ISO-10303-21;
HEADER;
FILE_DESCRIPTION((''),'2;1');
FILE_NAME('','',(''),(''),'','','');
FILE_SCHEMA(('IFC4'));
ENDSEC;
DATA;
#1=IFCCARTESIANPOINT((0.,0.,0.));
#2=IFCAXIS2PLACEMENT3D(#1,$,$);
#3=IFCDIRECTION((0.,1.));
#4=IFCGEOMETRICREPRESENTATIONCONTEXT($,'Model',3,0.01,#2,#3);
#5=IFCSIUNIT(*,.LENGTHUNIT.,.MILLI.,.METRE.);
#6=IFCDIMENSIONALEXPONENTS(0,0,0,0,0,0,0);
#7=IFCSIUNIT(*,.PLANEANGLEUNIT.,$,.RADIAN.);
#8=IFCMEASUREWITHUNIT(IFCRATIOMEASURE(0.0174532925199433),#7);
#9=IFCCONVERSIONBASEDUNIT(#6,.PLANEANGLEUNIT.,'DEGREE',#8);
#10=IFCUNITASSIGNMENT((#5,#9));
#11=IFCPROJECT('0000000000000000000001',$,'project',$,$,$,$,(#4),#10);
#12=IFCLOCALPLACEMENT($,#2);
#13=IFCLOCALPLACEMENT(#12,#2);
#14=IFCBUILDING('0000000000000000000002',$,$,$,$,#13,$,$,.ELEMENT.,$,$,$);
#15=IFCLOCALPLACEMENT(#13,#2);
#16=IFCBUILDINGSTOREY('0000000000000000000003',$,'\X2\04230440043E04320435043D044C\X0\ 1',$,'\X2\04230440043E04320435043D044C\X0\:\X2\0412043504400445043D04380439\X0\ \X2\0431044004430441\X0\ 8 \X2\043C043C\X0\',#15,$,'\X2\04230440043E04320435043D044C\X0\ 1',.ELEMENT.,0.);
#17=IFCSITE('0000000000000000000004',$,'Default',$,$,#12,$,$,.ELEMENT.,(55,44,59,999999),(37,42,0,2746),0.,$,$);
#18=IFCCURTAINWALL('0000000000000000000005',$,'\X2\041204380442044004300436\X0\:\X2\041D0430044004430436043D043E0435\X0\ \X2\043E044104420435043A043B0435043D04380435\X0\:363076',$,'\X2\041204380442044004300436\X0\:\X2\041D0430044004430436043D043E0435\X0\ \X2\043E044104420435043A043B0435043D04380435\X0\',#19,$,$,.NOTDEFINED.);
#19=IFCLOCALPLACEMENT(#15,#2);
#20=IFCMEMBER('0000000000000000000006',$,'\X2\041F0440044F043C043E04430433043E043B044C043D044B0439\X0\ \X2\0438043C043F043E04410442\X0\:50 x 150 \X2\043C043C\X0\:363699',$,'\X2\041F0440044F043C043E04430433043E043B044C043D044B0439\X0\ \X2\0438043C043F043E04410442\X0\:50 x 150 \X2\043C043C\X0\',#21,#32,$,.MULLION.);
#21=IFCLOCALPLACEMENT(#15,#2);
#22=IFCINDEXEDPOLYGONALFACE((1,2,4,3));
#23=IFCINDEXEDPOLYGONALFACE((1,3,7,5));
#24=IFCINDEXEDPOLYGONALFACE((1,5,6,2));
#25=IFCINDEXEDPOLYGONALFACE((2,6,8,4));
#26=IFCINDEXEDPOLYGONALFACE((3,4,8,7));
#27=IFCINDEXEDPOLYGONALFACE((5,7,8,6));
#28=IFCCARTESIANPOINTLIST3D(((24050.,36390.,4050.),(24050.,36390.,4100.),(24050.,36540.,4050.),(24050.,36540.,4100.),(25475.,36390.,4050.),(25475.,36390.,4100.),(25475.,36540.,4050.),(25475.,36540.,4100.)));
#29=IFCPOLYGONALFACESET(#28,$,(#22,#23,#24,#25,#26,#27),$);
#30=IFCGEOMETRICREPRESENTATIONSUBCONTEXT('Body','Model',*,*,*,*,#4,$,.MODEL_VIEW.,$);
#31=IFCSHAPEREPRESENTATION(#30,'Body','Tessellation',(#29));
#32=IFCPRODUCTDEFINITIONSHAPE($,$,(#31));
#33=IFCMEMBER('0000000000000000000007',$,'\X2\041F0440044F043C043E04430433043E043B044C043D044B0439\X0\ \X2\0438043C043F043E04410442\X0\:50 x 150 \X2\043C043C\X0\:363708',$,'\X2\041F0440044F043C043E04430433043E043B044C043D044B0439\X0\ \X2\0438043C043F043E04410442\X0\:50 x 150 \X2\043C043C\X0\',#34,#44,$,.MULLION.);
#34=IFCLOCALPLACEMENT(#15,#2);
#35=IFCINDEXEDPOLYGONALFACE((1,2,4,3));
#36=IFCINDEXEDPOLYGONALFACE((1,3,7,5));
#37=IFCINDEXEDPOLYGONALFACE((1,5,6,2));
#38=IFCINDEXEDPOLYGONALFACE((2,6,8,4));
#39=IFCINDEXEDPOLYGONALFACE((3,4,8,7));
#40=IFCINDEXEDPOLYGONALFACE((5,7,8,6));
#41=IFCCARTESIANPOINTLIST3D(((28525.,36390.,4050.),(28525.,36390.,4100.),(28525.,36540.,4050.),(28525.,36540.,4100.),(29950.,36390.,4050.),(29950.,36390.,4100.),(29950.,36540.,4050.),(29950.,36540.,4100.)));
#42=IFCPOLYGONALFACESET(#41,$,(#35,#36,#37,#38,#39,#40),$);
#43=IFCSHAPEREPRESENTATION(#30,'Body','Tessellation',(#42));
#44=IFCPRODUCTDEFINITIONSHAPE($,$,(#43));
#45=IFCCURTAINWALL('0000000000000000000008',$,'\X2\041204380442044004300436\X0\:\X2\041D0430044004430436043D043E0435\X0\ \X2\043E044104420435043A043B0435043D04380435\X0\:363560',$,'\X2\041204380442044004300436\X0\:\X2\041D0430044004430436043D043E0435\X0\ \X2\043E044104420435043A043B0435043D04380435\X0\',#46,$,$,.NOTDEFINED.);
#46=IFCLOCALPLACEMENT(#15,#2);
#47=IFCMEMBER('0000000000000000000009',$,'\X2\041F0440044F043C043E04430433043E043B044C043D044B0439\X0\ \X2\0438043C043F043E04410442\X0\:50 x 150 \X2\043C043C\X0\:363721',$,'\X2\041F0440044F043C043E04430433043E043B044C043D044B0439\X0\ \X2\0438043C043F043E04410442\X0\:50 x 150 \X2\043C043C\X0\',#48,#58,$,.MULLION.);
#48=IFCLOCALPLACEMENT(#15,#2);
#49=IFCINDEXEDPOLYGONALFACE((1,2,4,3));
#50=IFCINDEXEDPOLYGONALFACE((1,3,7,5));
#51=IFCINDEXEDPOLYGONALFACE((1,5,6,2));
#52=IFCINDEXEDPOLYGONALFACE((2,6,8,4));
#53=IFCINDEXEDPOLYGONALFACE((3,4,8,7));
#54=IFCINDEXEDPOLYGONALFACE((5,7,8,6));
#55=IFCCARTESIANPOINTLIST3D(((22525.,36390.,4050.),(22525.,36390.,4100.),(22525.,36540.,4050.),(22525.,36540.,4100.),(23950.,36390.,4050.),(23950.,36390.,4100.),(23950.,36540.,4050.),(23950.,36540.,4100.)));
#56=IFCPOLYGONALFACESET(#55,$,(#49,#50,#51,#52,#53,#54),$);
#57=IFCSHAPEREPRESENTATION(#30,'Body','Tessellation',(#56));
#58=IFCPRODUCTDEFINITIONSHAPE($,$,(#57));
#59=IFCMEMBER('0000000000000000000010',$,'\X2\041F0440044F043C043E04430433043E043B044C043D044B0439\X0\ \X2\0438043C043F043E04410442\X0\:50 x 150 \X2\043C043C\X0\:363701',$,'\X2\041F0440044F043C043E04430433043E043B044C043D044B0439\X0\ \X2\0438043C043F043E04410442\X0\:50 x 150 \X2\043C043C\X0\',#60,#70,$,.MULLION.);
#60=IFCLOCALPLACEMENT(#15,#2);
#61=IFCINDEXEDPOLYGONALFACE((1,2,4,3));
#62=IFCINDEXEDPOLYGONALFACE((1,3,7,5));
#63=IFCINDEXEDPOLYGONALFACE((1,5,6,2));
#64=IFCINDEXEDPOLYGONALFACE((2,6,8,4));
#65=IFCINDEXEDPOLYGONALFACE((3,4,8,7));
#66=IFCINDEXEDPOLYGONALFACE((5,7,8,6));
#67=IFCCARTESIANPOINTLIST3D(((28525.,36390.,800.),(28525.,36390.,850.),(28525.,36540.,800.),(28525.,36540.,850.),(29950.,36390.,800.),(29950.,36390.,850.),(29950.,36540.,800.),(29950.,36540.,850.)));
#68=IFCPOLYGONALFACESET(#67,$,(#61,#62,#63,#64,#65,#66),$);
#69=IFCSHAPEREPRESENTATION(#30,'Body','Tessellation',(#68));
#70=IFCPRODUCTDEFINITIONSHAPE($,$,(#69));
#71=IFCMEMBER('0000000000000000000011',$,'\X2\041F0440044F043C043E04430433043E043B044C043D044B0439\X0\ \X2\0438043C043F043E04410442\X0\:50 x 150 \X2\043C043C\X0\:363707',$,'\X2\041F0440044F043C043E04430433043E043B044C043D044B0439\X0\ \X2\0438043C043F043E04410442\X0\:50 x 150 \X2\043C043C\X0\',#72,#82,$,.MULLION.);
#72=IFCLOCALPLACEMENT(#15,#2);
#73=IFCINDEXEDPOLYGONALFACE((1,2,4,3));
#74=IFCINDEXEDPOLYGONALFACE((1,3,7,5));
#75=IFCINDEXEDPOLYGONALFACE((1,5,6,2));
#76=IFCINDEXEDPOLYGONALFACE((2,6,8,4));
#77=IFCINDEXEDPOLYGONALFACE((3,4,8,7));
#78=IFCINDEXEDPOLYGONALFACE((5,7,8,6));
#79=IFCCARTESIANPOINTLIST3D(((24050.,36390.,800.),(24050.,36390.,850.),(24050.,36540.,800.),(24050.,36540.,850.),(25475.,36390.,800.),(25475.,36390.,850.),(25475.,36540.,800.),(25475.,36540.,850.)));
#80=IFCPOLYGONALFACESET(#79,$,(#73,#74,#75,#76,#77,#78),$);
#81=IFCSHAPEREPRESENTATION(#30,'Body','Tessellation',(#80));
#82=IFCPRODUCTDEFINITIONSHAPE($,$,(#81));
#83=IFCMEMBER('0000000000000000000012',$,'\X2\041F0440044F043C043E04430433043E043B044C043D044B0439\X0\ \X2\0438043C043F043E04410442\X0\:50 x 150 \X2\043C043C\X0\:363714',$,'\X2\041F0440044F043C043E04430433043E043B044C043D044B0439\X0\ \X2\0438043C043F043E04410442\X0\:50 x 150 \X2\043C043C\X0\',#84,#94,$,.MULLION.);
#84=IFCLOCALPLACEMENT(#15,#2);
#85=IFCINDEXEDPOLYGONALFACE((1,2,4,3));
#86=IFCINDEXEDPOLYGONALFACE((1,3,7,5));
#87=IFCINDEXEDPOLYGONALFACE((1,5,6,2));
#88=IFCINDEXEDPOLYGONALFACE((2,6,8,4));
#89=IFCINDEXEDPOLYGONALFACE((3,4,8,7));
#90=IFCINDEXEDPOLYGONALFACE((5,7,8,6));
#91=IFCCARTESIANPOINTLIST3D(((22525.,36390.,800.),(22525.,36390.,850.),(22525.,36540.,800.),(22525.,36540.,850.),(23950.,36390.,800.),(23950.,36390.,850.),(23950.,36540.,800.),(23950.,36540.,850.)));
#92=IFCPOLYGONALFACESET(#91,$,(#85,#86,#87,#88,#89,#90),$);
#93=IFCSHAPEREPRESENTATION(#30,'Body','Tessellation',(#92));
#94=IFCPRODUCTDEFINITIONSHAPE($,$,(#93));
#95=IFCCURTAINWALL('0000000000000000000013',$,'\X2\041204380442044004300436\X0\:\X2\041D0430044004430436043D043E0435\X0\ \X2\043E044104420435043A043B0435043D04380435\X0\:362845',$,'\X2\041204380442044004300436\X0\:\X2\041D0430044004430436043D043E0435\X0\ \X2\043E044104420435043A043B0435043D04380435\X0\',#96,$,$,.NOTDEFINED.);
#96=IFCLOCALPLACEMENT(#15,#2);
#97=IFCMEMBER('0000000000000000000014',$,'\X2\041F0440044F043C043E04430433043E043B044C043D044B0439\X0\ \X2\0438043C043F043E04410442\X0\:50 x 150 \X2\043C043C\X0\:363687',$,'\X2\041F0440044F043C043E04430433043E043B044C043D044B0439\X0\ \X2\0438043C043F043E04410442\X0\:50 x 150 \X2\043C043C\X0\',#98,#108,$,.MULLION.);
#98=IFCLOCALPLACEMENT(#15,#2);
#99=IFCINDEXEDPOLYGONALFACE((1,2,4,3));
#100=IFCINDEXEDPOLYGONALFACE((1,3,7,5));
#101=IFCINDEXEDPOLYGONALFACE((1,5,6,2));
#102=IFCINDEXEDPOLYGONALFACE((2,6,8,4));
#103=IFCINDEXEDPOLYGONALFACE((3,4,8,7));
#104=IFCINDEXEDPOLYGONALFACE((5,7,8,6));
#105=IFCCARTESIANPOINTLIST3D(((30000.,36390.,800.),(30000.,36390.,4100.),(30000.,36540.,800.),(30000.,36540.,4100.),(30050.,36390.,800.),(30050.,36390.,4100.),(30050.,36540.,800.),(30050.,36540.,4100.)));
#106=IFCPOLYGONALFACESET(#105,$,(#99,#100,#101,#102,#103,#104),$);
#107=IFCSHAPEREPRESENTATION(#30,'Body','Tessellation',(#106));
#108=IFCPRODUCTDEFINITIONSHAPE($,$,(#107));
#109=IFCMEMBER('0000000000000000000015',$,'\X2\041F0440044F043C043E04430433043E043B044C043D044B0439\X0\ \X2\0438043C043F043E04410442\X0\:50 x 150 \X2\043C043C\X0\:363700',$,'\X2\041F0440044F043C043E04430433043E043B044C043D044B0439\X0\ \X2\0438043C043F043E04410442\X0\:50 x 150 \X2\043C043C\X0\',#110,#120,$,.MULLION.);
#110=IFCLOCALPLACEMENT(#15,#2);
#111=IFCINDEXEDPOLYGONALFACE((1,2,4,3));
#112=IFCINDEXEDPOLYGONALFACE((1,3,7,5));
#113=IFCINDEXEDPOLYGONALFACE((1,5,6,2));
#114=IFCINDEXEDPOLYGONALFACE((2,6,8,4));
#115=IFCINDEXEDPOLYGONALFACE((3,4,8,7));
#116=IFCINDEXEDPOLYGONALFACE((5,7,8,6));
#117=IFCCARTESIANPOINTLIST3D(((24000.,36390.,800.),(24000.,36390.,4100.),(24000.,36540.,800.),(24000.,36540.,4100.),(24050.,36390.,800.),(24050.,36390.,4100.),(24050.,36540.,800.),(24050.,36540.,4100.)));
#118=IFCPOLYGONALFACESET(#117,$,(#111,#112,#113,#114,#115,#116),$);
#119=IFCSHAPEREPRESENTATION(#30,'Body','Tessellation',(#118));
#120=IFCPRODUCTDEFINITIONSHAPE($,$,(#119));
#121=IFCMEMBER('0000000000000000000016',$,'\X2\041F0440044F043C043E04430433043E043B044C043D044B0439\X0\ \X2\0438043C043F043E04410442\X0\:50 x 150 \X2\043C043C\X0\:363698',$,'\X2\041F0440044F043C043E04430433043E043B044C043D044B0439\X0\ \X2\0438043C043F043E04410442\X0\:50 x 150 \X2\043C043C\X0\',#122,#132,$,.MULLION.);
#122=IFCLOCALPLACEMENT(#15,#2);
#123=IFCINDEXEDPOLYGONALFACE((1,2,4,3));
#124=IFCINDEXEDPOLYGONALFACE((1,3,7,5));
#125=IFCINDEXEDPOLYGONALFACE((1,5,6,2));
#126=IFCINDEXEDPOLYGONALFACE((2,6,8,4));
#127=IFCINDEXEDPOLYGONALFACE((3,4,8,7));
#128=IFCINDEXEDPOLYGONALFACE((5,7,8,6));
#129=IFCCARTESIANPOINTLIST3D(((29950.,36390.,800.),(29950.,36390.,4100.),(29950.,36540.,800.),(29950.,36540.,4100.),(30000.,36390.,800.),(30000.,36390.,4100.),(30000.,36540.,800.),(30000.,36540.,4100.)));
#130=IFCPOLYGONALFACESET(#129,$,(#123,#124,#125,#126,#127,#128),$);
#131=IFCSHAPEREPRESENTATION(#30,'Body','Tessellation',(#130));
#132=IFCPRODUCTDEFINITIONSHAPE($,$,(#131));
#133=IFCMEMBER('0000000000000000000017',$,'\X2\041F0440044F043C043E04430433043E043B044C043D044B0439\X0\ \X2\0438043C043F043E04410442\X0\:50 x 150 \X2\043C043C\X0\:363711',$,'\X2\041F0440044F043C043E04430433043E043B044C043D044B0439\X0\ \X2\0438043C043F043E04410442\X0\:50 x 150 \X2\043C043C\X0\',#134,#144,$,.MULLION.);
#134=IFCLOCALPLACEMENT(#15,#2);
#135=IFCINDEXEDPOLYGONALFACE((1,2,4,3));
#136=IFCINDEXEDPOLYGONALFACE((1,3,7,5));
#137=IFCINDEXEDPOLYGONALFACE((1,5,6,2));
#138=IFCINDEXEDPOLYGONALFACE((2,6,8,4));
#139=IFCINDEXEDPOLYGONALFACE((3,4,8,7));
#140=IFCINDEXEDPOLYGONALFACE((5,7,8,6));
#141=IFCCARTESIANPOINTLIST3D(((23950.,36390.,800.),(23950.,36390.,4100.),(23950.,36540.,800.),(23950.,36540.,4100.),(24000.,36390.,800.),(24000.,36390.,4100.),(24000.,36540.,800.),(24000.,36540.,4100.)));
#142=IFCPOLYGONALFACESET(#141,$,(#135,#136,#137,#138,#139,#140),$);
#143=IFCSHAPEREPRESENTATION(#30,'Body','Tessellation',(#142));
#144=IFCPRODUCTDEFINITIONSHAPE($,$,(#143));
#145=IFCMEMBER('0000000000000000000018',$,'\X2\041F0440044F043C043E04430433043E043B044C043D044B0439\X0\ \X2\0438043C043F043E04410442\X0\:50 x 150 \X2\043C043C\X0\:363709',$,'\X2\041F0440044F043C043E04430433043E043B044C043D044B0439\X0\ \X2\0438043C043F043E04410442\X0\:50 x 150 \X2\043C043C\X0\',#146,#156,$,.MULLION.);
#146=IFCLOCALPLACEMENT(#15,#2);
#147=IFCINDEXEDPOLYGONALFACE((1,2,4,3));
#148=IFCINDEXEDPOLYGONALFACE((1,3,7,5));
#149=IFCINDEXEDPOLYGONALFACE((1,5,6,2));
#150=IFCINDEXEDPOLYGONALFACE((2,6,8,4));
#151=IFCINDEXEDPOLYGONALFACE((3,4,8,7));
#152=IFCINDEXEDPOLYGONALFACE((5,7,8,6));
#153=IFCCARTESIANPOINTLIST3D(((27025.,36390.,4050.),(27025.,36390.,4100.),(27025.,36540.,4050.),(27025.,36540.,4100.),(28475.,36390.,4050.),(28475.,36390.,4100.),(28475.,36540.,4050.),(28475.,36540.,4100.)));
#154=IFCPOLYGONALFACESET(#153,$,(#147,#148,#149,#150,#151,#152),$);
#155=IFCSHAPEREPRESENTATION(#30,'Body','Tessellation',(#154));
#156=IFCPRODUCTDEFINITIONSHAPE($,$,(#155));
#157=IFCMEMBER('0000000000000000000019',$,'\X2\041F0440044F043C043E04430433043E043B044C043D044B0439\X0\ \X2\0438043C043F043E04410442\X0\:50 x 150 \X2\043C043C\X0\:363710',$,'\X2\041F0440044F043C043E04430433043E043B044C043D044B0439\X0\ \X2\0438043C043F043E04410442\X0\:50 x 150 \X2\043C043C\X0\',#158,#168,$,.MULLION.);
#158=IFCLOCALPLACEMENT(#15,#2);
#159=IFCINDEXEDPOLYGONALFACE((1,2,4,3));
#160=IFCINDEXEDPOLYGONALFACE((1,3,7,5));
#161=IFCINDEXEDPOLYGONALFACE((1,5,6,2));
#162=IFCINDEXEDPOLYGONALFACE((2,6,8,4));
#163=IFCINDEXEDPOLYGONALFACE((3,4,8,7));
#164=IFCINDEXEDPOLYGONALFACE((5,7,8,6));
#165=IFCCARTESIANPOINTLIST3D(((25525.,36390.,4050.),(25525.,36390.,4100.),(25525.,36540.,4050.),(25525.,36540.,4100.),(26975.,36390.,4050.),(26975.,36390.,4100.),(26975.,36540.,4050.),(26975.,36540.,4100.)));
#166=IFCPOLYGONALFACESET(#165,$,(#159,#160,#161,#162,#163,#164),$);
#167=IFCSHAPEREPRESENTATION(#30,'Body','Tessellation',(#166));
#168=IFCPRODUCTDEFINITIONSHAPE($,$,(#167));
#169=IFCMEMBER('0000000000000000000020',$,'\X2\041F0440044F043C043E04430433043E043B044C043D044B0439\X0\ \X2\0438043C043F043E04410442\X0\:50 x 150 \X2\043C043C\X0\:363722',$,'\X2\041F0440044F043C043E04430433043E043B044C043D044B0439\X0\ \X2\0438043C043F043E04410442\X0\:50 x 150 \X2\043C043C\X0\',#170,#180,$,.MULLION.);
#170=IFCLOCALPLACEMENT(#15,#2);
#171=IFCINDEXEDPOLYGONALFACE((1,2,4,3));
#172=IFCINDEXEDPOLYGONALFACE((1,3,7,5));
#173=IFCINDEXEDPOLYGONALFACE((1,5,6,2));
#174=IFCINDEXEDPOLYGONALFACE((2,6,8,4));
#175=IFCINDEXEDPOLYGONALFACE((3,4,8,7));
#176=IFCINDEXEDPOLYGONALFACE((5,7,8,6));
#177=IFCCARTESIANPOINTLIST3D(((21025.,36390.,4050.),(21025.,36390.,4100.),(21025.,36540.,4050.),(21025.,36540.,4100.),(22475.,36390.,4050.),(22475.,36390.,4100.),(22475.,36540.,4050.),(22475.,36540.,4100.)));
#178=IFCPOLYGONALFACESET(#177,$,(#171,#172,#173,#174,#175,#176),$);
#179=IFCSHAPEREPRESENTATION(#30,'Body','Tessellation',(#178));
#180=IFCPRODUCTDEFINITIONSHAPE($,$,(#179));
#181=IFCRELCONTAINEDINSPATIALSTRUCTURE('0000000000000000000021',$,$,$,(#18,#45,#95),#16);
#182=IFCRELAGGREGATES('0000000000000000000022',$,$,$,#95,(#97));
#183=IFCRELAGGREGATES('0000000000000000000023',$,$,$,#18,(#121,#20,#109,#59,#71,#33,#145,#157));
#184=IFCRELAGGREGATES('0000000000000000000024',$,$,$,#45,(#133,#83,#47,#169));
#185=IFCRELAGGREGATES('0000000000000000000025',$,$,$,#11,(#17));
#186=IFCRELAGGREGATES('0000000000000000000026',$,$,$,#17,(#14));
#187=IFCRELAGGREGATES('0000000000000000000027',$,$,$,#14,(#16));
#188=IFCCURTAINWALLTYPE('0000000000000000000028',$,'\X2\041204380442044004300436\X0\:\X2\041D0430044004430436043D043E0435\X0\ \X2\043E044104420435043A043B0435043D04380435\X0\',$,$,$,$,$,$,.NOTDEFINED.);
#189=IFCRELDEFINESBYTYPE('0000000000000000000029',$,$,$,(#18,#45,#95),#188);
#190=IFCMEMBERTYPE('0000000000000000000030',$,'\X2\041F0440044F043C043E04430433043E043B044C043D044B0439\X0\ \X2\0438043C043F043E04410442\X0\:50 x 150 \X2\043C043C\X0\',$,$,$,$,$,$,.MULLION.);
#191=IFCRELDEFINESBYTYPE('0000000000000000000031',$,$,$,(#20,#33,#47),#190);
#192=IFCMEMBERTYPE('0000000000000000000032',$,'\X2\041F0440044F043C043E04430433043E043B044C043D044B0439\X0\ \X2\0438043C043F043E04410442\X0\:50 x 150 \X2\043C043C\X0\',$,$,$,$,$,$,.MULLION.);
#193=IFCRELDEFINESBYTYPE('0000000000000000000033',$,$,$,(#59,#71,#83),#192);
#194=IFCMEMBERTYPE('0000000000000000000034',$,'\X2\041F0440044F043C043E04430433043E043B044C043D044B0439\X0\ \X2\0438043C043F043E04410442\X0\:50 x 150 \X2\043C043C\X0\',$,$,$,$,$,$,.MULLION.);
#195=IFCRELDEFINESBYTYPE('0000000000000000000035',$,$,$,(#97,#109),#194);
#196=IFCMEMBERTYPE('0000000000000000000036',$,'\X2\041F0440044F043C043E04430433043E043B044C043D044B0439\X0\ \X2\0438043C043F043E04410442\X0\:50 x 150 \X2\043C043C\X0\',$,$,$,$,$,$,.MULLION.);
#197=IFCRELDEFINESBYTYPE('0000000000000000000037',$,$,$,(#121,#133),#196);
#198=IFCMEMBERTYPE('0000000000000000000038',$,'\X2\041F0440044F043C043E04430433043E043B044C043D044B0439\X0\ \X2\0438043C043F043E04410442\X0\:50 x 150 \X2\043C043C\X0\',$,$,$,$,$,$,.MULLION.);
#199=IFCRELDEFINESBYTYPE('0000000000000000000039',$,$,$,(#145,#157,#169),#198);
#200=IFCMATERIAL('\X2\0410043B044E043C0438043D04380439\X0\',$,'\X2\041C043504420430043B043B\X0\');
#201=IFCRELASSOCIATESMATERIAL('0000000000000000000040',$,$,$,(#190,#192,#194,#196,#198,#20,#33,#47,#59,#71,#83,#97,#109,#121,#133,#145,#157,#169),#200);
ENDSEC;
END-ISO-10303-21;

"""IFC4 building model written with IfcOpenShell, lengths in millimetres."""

from ifc_helpers import new_model, entity, si_unit, converted_unit, direction, frame, origin, origin_2d_with_axis, place, context, subcontext, project, spatial, rectangle, extrude, source, transform, mapped, material, material_profile, profile_set, profile_usage, type_object, type_shapes, element, aggregate, save


model = new_model("IFC4")

# Units and contexts
model_context = context("Model", 3, precision=0.01, world=origin(), true_north=direction((0.0, 1.0)))
body_context = subcontext(model_context, "Body", "Model", "MODEL_VIEW")
ifc_project = project(units=[si_unit("LENGTHUNIT", "METRE", prefix="MILLI"), converted_unit("PLANEANGLEUNIT", "DEGREE", entity("IfcRatioMeasure", 0.0174532925199433), si_unit("PLANEANGLEUNIT", "RADIAN"), dimensions=[0, 0, 0, 0, 0, 0, 0])], contexts=[model_context])

# Site, building, storey
site_placement = place(None, origin())
site = spatial("IfcSite", under=ifc_project, at=site_placement, Name="Default", CompositionType="ELEMENT", RefLatitude=(55, 44, 59, 999999), RefLongitude=(37, 42, 0, 2746), RefElevation=0.0)
building_placement = place(site_placement, origin())
building = spatial("IfcBuilding", under=site, at=building_placement, CompositionType="ELEMENT")
storey_placement = place(building_placement, origin())
storey = spatial("IfcBuildingStorey", under=building, at=storey_placement, Name="Уровень 1", ObjectType="Уровень:Верхний брус 8 мм", LongName="Уровень 1", CompositionType="ELEMENT", Elevation=0.0)

# Curtain wall, members
curtain_wall_type = type_object("IfcCurtainWallType", Name="Витраж:Наружное остекление", PredefinedType="NOTDEFINED")
curtain_wall_1_placement = place(storey_placement, origin())
curtain_wall_1 = element("IfcCurtainWall", 1, at=curtain_wall_1_placement, inside=storey, type_object=curtain_wall_type, Name="Витраж:Наружное остекление:363076", ObjectType="Витраж:Наружное остекление", PredefinedType="NOTDEFINED")
ifc_material_1 = material(Name="Алюминий", Category="Металл")
ifc_material_profile = material_profile(ifc_material_1, rectangle(XDim=150.0, YDim=50.0, at=origin_2d_with_axis()), Name="50 x 150 мм")
ifc_profile_set = profile_set([ifc_material_profile], Name="50 x 150 мм")
ifc_profile_usage_1 = profile_usage(ifc_profile_set)
member_type_1 = type_object("IfcMemberType", Name="Прямоугольный импост:50 x 150 мм", PredefinedType="MULLION", material=ifc_profile_set)
shared_shape_1 = source(origin(), body_context, "Body", "SweptSolid", [
    extrude(rectangle(XDim=150.0, YDim=50.0, at=origin_2d_with_axis()), frame((-25.0, 0.0, -1425.0), z_axis=(0.0, 0.0, 1.0), x_axis=(0.0, -1.0, 0.0)), (0.0, 0.0, 1.0), 1425.0),
])
type_shapes(member_type_1, [shared_shape_1])
member_1_placement = place(storey_placement, frame((24050.0, 36465.0, 4100.0), z_axis=(-1.0, 0.0, 0.0), x_axis=(0.0, 0.0, 1.0)))
member_1 = element("IfcMember", 2, at=member_1_placement, type_object=member_type_1, material=ifc_profile_usage_1, Name="Прямоугольный импост:50 x 150 мм:363699", ObjectType="Прямоугольный импост:50 x 150 мм", PredefinedType="MULLION", context=body_context, shape_type="MappedRepresentation", body=[
    mapped(shared_shape_1, transform((0.0, 0.0, 0.0), scale=1.0)),
])
ifc_profile_usage_2 = profile_usage(ifc_profile_set)
member_2_placement = place(storey_placement, frame((28525.0, 36465.0, 4100.0), z_axis=(-1.0, 0.0, 0.0), x_axis=(0.0, 0.0, 1.0)))
member_2 = element("IfcMember", 3, at=member_2_placement, type_object=member_type_1, material=ifc_profile_usage_2, Name="Прямоугольный импост:50 x 150 мм:363708", ObjectType="Прямоугольный импост:50 x 150 мм", PredefinedType="MULLION", context=body_context, shape_type="MappedRepresentation", body=[
    mapped(shared_shape_1, transform((0.0, 0.0, 0.0), scale=1.0)),
])

# Curtain wall, member
curtain_wall_2_placement = place(storey_placement, origin())
curtain_wall_2 = element("IfcCurtainWall", 4, at=curtain_wall_2_placement, inside=storey, type_object=curtain_wall_type, Name="Витраж:Наружное остекление:363560", ObjectType="Витраж:Наружное остекление", PredefinedType="NOTDEFINED")
ifc_profile_usage_3 = profile_usage(ifc_profile_set)
member_3_placement = place(storey_placement, frame((22525.0, 36465.0, 4100.0), z_axis=(-1.0, 0.0, 0.0), x_axis=(0.0, 0.0, 1.0)))
member_3 = element("IfcMember", 5, at=member_3_placement, type_object=member_type_1, material=ifc_profile_usage_3, Name="Прямоугольный импост:50 x 150 мм:363721", ObjectType="Прямоугольный импост:50 x 150 мм", PredefinedType="MULLION", context=body_context, shape_type="MappedRepresentation", body=[
    mapped(shared_shape_1, transform((0.0, 0.0, 0.0), scale=1.0)),
])

# Members
ifc_profile_usage_4 = profile_usage(ifc_profile_set)
member_type_2 = type_object("IfcMemberType", Name="Прямоугольный импост:50 x 150 мм", PredefinedType="MULLION", material=ifc_profile_set)
shared_shape_2 = source(origin(), body_context, "Body", "SweptSolid", [
    extrude(rectangle(XDim=150.0, YDim=50.0, at=origin_2d_with_axis()), frame((-25.0, 0.0, -1425.0), z_axis=(0.0, 0.0, 1.0), x_axis=(0.0, -1.0, 0.0)), (0.0, 0.0, 1.0), 1425.0),
])
type_shapes(member_type_2, [shared_shape_2])
member_4_placement = place(storey_placement, frame((29950.0, 36465.0, 800.0), z_axis=(1.0, 0.0, 0.0), x_axis=(0.0, 0.0, -1.0)))
member_4 = element("IfcMember", 6, at=member_4_placement, type_object=member_type_2, material=ifc_profile_usage_4, Name="Прямоугольный импост:50 x 150 мм:363701", ObjectType="Прямоугольный импост:50 x 150 мм", PredefinedType="MULLION", context=body_context, shape_type="MappedRepresentation", body=[
    mapped(shared_shape_2, transform((0.0, 0.0, 0.0), scale=1.0)),
])
ifc_profile_usage_5 = profile_usage(ifc_profile_set)
member_5_placement = place(storey_placement, frame((25475.0, 36465.0, 800.0), z_axis=(1.0, 0.0, 0.0), x_axis=(0.0, 0.0, -1.0)))
member_5 = element("IfcMember", 7, at=member_5_placement, type_object=member_type_2, material=ifc_profile_usage_5, Name="Прямоугольный импост:50 x 150 мм:363707", ObjectType="Прямоугольный импост:50 x 150 мм", PredefinedType="MULLION", context=body_context, shape_type="MappedRepresentation", body=[
    mapped(shared_shape_2, transform((0.0, 0.0, 0.0), scale=1.0)),
])
ifc_profile_usage_6 = profile_usage(ifc_profile_set)
member_6_placement = place(storey_placement, frame((23950.0, 36465.0, 800.0), z_axis=(1.0, 0.0, 0.0), x_axis=(0.0, 0.0, -1.0)))
member_6 = element("IfcMember", 8, at=member_6_placement, type_object=member_type_2, material=ifc_profile_usage_6, Name="Прямоугольный импост:50 x 150 мм:363714", ObjectType="Прямоугольный импост:50 x 150 мм", PredefinedType="MULLION", context=body_context, shape_type="MappedRepresentation", body=[
    mapped(shared_shape_2, transform((0.0, 0.0, 0.0), scale=1.0)),
])

# Curtain wall, member
curtain_wall_3_placement = place(storey_placement, origin())
curtain_wall_3 = element("IfcCurtainWall", 9, at=curtain_wall_3_placement, inside=storey, type_object=curtain_wall_type, Name="Витраж:Наружное остекление:362845", ObjectType="Витраж:Наружное остекление", PredefinedType="NOTDEFINED")
ifc_profile_usage_7 = profile_usage(ifc_profile_set)
member_type_3 = type_object("IfcMemberType", Name="Прямоугольный импост:50 x 150 мм", PredefinedType="MULLION", material=ifc_profile_set)
shared_shape_3 = source(origin(), body_context, "Body", "SweptSolid", [
    extrude(rectangle(XDim=150.0, YDim=50.0, at=origin_2d_with_axis()), frame((-25.0, 0.0, -3300.0), z_axis=(0.0, 0.0, 1.0), x_axis=(0.0, -1.0, 0.0)), (0.0, 0.0, 1.0), 3300.0),
])
type_shapes(member_type_3, [shared_shape_3])
member_7_placement = place(storey_placement, frame((30000.0, 36465.0, 800.0), z_axis=(0.0, 0.0, -1.0), x_axis=(-1.0, 0.0, 0.0)))
member_7 = element("IfcMember", 10, at=member_7_placement, type_object=member_type_3, material=ifc_profile_usage_7, Name="Прямоугольный импост:50 x 150 мм:363687", ObjectType="Прямоугольный импост:50 x 150 мм", PredefinedType="MULLION", context=body_context, shape_type="MappedRepresentation", body=[
    mapped(shared_shape_3, transform((0.0, 0.0, 0.0), scale=1.0)),
])
aggregate(curtain_wall_3, [member_7])

# Members
ifc_profile_usage_8 = profile_usage(ifc_profile_set)
member_8_placement = place(storey_placement, frame((24000.0, 36465.0, 800.0), z_axis=(0.0, 0.0, -1.0), x_axis=(-1.0, 0.0, 0.0)))
member_8 = element("IfcMember", 11, at=member_8_placement, type_object=member_type_3, material=ifc_profile_usage_8, Name="Прямоугольный импост:50 x 150 мм:363700", ObjectType="Прямоугольный импост:50 x 150 мм", PredefinedType="MULLION", context=body_context, shape_type="MappedRepresentation", body=[
    mapped(shared_shape_3, transform((0.0, 0.0, 0.0), scale=1.0)),
])
ifc_profile_usage_9 = profile_usage(ifc_profile_set)
member_type_4 = type_object("IfcMemberType", Name="Прямоугольный импост:50 x 150 мм", PredefinedType="MULLION", material=ifc_profile_set)
shared_shape_4 = source(origin(), body_context, "Body", "SweptSolid", [
    extrude(rectangle(XDim=150.0, YDim=50.0, at=origin_2d_with_axis()), frame((-25.0, 0.0, -3300.0), z_axis=(0.0, 0.0, 1.0), x_axis=(0.0, -1.0, 0.0)), (0.0, 0.0, 1.0), 3300.0),
])
type_shapes(member_type_4, [shared_shape_4])
member_9_placement = place(storey_placement, frame((30000.0, 36465.0, 4100.0)))
member_9 = element("IfcMember", 12, at=member_9_placement, type_object=member_type_4, material=ifc_profile_usage_9, Name="Прямоугольный импост:50 x 150 мм:363698", ObjectType="Прямоугольный импост:50 x 150 мм", PredefinedType="MULLION", context=body_context, shape_type="MappedRepresentation", body=[
    mapped(shared_shape_4, transform((0.0, 0.0, 0.0), scale=1.0)),
])
ifc_profile_usage_10 = profile_usage(ifc_profile_set)
member_10_placement = place(storey_placement, frame((24000.0, 36465.0, 4100.0)))
member_10 = element("IfcMember", 13, at=member_10_placement, type_object=member_type_4, material=ifc_profile_usage_10, Name="Прямоугольный импост:50 x 150 мм:363711", ObjectType="Прямоугольный импост:50 x 150 мм", PredefinedType="MULLION", context=body_context, shape_type="MappedRepresentation", body=[
    mapped(shared_shape_4, transform((0.0, 0.0, 0.0), scale=1.0)),
])
ifc_profile_usage_11 = profile_usage(ifc_profile_set)
member_type_5 = type_object("IfcMemberType", Name="Прямоугольный импост:50 x 150 мм", PredefinedType="MULLION", material=ifc_profile_set)
shared_shape_5 = source(origin(), body_context, "Body", "SweptSolid", [
    extrude(rectangle(XDim=150.0, YDim=50.0, at=origin_2d_with_axis()), frame((-25.0, 0.0, -1450.0), z_axis=(0.0, 0.0, 1.0), x_axis=(0.0, -1.0, 0.0)), (0.0, 0.0, 1.0), 1450.0),
])
type_shapes(member_type_5, [shared_shape_5])
member_11_placement = place(storey_placement, frame((27025.0, 36465.0, 4100.0), z_axis=(-1.0, 0.0, 0.0), x_axis=(0.0, 0.0, 1.0)))
member_11 = element("IfcMember", 14, at=member_11_placement, type_object=member_type_5, material=ifc_profile_usage_11, Name="Прямоугольный импост:50 x 150 мм:363709", ObjectType="Прямоугольный импост:50 x 150 мм", PredefinedType="MULLION", context=body_context, shape_type="MappedRepresentation", body=[
    mapped(shared_shape_5, transform((0.0, 0.0, 0.0), scale=1.0)),
])
ifc_profile_usage_12 = profile_usage(ifc_profile_set)
member_12_placement = place(storey_placement, frame((25525.0, 36465.0, 4100.0), z_axis=(-1.0, 0.0, 0.0), x_axis=(0.0, 0.0, 1.0)))
member_12 = element("IfcMember", 15, at=member_12_placement, type_object=member_type_5, material=ifc_profile_usage_12, Name="Прямоугольный импост:50 x 150 мм:363710", ObjectType="Прямоугольный импост:50 x 150 мм", PredefinedType="MULLION", context=body_context, shape_type="MappedRepresentation", body=[
    mapped(shared_shape_5, transform((0.0, 0.0, 0.0), scale=1.0)),
])
ifc_profile_usage_13 = profile_usage(ifc_profile_set)
member_13_placement = place(storey_placement, frame((21025.0, 36465.0, 4100.0), z_axis=(-1.0, 0.0, 0.0), x_axis=(0.0, 0.0, 1.0)))
member_13 = element("IfcMember", 16, at=member_13_placement, type_object=member_type_5, material=ifc_profile_usage_13, Name="Прямоугольный импост:50 x 150 мм:363722", ObjectType="Прямоугольный импост:50 x 150 мм", PredefinedType="MULLION", context=body_context, shape_type="MappedRepresentation", body=[
    mapped(shared_shape_5, transform((0.0, 0.0, 0.0), scale=1.0)),
])
aggregate(curtain_wall_1, [member_9, member_1, member_8, member_4, member_5, member_2, member_11, member_12])

aggregate(curtain_wall_2, [member_10, member_6, member_3, member_13])

save(model, "model.ifc")
